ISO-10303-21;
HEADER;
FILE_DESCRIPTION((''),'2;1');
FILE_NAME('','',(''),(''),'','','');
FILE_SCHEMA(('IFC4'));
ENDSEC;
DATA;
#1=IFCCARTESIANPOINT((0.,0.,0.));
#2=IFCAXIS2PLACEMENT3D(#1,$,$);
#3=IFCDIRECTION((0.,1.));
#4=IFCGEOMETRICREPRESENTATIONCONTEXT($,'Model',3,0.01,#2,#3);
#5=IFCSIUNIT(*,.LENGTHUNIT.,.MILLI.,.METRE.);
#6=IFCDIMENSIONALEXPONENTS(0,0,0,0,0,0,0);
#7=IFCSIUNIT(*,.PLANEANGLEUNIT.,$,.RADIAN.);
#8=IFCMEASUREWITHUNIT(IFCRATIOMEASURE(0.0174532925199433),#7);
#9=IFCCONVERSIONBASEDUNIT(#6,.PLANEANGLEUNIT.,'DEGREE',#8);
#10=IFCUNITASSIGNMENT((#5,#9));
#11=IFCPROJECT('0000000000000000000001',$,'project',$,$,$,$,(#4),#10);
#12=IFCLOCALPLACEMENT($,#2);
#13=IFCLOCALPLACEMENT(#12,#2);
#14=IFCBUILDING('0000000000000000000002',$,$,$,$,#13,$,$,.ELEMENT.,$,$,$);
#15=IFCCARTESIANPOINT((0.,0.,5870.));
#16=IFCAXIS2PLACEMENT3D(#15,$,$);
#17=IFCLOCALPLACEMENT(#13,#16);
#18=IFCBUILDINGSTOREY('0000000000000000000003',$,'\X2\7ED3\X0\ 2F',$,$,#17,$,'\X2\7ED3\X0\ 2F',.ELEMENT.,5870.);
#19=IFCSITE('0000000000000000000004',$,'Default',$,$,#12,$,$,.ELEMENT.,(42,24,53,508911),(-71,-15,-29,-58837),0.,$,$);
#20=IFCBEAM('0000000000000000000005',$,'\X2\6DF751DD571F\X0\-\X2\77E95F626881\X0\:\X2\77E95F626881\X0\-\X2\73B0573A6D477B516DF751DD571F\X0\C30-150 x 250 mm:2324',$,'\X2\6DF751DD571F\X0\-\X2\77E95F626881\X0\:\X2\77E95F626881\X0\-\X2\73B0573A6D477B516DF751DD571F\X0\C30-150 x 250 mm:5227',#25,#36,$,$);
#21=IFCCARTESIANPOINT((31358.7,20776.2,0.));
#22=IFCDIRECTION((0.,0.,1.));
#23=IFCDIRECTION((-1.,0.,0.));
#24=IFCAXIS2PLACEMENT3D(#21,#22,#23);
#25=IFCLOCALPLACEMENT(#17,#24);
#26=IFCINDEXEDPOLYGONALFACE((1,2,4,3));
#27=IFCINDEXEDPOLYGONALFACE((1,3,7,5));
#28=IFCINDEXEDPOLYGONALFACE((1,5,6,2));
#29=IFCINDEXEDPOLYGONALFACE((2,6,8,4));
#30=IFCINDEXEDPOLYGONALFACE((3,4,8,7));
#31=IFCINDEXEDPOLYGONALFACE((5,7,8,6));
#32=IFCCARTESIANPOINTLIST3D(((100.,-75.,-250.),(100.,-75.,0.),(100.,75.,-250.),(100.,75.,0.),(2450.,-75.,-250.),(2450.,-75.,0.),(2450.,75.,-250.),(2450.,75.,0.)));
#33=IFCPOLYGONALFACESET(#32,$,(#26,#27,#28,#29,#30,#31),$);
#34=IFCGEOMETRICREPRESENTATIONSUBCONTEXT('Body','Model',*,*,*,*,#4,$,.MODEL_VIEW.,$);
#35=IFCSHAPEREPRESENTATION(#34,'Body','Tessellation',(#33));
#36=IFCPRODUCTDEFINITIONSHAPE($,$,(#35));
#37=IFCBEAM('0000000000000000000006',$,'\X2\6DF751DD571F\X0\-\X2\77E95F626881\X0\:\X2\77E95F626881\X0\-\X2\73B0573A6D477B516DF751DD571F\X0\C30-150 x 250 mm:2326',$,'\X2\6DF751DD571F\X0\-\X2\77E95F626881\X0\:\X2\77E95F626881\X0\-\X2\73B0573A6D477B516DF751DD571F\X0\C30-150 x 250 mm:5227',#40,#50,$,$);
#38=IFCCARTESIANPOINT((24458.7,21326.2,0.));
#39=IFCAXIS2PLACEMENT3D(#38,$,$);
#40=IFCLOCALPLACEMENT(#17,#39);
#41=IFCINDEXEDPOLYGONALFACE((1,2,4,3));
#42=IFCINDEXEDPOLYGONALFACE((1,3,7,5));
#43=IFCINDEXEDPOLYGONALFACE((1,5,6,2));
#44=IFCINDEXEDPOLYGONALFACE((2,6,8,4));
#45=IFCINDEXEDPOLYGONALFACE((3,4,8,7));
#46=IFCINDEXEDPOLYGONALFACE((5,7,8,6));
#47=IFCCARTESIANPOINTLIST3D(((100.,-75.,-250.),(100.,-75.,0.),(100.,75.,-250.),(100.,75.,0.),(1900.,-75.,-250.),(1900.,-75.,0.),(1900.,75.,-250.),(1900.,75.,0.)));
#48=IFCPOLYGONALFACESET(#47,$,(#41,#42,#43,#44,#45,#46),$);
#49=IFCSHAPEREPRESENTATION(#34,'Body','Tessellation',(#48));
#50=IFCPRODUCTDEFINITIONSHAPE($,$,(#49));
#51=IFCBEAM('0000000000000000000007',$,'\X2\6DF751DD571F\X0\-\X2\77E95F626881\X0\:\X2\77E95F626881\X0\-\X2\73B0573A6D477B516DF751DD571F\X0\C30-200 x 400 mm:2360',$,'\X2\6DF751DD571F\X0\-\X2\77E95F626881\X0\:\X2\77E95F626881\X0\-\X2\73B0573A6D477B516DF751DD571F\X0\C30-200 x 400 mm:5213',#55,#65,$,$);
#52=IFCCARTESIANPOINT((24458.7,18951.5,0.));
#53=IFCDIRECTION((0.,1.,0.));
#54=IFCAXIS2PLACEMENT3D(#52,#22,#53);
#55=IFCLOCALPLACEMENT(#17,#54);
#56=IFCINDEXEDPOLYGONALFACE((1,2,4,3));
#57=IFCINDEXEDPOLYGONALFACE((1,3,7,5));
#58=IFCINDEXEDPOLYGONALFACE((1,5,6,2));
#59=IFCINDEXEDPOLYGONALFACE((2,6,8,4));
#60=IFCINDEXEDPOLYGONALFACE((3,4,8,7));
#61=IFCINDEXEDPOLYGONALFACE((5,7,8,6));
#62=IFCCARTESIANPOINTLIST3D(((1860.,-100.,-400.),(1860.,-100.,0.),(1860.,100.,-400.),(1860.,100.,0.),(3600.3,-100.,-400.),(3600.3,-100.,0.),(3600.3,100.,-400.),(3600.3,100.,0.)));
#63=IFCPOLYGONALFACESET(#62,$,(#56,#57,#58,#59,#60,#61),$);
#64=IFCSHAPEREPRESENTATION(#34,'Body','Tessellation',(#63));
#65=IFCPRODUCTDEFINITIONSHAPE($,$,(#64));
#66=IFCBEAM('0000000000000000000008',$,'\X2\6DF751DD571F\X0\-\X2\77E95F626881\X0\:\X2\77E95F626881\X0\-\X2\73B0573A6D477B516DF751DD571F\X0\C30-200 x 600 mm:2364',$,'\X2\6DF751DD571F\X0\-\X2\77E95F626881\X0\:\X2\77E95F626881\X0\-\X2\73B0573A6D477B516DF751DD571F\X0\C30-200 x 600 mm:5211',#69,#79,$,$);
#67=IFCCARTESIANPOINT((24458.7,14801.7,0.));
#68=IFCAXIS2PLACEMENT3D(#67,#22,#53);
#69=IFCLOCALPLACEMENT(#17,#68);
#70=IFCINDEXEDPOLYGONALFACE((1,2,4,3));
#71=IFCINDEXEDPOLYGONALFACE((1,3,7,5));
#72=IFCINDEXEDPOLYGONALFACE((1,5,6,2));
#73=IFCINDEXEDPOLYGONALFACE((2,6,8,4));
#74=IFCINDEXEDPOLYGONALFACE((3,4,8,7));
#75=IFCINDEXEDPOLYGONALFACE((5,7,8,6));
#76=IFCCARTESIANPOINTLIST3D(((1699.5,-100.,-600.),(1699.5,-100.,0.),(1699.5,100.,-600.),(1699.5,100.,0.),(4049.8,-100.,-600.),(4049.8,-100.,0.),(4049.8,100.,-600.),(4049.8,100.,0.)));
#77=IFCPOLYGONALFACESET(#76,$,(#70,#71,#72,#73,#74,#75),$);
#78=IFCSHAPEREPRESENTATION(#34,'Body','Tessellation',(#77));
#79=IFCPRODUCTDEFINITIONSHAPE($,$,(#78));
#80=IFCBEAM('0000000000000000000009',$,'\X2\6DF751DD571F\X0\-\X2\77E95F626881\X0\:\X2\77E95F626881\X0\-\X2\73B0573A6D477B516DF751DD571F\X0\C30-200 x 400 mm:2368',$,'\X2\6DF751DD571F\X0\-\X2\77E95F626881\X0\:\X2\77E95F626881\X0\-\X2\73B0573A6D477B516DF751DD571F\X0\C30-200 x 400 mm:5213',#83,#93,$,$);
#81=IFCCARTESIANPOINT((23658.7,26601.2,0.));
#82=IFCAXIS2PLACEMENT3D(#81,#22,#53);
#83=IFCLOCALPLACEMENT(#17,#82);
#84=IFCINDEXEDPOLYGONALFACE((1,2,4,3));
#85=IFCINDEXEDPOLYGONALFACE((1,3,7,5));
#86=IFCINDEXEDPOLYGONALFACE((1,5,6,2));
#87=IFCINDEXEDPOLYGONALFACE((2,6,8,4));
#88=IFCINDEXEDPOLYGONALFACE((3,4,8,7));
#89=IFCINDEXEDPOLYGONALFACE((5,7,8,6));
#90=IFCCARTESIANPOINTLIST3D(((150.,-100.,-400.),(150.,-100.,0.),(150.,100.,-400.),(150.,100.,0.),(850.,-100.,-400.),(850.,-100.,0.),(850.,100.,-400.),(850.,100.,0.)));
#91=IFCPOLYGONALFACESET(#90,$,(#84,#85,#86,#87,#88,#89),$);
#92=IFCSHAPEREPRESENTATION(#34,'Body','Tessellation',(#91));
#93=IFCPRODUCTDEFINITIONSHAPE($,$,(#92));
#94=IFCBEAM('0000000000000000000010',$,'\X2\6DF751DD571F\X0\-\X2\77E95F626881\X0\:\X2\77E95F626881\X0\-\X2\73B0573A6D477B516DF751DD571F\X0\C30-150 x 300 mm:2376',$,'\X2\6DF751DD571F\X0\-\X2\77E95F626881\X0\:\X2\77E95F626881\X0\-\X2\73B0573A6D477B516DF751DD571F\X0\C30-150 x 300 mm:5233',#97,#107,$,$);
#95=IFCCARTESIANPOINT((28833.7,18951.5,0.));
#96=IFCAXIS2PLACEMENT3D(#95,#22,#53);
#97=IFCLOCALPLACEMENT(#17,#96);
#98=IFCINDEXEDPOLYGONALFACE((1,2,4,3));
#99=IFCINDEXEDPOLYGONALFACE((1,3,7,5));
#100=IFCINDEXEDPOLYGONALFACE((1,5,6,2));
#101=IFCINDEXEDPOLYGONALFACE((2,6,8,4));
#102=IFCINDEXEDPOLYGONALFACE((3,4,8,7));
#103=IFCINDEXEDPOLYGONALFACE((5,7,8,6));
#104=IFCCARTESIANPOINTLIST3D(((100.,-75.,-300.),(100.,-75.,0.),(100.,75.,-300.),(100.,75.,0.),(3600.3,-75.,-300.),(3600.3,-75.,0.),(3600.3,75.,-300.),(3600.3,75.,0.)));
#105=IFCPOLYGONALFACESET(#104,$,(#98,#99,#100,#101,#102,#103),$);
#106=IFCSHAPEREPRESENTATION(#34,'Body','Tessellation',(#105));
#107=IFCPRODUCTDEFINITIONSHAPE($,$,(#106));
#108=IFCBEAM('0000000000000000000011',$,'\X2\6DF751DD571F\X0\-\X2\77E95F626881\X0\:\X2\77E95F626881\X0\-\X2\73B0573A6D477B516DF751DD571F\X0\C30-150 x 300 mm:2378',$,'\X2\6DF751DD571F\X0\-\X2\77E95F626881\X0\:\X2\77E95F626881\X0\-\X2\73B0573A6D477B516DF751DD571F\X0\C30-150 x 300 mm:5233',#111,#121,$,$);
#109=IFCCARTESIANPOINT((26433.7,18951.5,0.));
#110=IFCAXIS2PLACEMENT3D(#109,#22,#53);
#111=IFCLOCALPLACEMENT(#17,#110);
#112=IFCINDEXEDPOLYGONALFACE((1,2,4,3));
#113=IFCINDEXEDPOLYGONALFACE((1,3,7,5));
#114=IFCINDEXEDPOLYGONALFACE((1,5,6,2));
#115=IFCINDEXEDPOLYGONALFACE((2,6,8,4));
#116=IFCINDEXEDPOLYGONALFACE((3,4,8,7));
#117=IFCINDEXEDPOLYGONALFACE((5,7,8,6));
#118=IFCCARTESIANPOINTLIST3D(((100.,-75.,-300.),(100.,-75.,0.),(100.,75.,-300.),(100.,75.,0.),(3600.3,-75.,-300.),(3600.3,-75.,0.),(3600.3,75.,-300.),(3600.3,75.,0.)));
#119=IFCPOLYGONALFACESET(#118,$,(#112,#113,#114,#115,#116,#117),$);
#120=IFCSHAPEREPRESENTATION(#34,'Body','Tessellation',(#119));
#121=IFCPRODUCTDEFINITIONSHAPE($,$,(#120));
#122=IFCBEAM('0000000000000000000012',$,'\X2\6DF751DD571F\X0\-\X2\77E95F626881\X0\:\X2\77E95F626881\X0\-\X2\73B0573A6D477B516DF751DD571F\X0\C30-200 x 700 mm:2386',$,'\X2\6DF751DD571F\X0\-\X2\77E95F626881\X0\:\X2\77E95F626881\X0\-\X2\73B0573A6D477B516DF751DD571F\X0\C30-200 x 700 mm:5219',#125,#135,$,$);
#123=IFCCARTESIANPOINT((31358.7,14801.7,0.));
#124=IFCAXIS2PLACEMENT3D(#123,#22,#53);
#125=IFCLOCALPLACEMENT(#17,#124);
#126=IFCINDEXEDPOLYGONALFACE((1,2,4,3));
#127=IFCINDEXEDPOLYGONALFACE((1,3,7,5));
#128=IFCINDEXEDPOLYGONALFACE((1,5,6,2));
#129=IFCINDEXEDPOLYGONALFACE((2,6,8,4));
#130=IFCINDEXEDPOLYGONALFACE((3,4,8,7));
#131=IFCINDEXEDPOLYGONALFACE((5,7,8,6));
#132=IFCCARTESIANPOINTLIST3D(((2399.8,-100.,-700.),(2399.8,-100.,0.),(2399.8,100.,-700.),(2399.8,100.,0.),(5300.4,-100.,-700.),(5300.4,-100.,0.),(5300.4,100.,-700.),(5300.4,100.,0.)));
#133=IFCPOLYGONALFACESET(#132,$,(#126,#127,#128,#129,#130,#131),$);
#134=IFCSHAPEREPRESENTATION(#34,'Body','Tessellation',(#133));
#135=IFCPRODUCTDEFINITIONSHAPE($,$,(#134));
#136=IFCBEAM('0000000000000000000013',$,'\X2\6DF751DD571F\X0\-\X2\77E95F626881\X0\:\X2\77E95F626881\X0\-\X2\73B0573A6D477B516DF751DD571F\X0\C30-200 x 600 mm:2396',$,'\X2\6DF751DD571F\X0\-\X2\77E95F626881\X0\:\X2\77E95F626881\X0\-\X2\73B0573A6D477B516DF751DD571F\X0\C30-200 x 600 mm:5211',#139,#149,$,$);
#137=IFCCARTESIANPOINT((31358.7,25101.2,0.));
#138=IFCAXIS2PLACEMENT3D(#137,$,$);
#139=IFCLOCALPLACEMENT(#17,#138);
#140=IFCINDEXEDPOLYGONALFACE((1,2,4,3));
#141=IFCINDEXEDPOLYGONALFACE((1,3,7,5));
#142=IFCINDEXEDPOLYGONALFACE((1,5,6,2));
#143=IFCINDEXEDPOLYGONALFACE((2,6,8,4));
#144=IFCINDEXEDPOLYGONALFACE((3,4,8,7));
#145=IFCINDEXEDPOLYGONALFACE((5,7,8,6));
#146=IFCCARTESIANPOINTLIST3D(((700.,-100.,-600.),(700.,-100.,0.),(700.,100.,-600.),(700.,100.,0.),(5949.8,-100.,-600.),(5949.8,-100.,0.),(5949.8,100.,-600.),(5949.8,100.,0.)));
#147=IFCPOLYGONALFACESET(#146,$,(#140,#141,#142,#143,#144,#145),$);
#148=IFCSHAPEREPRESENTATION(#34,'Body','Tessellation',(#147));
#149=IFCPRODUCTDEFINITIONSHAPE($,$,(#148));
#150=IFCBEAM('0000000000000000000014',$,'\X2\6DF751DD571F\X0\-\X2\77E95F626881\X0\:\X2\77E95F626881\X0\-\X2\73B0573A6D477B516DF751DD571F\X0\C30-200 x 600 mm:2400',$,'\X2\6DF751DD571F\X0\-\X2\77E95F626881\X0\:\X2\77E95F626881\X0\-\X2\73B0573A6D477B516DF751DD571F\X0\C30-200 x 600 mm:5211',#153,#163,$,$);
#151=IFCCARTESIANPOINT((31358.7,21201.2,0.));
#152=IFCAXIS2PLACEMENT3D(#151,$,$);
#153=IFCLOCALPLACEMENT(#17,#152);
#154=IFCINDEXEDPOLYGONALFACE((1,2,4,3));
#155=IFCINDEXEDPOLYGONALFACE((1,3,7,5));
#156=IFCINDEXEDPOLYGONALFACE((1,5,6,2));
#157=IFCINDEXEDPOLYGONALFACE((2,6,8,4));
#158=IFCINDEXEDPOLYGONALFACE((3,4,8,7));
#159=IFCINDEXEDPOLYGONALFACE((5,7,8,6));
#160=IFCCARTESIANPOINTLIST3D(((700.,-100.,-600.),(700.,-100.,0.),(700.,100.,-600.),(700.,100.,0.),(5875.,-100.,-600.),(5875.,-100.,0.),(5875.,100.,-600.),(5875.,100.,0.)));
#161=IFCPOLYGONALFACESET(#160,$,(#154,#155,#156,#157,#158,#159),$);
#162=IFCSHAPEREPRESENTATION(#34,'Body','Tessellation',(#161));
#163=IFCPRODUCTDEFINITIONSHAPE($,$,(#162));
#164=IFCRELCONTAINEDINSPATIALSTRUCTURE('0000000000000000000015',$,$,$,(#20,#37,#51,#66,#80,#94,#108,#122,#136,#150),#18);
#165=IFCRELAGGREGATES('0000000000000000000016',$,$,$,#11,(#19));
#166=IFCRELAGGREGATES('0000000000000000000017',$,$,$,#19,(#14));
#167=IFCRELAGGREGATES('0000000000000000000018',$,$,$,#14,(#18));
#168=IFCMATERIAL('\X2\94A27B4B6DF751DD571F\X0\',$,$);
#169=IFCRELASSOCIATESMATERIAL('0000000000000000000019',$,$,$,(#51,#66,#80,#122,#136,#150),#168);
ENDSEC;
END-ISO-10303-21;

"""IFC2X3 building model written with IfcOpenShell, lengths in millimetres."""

from ifc_helpers import new_model, entity, si_unit, converted_unit, direction, frame, frame_2d, origin, place, context, subcontext, project, spatial, rectangle, extrude, material, element, save


model = new_model("IFC2X3")

# Units and contexts
model_context = context("Model", 3, precision=0.01, world=origin(), true_north=direction((0.0, 1.0)))
body_context = subcontext(model_context, "Body", "Model", "MODEL_VIEW")
ifc_project = project(units=[si_unit("LENGTHUNIT", "METRE", prefix="MILLI"), converted_unit("PLANEANGLEUNIT", "DEGREE", entity("IfcRatioMeasure", 0.0174532925199433), si_unit("PLANEANGLEUNIT", "RADIAN"), dimensions=[0, 0, 0, 0, 0, 0, 0])], contexts=[model_context])

# Site, building, storey
site_placement = place(None, origin())
site = spatial("IfcSite", under=ifc_project, at=site_placement, Name="Default", CompositionType="ELEMENT", RefLatitude=(42, 24, 53, 508911), RefLongitude=(-71, -15, -29, -58837), RefElevation=0.0)
building_placement = place(site_placement, origin())
building = spatial("IfcBuilding", under=site, at=building_placement, CompositionType="ELEMENT")
storey_placement = place(building_placement, frame((0.0, 0.0, 5870.0)))
storey = spatial("IfcBuildingStorey", under=building, at=storey_placement, Name="结 2F", LongName="结 2F", CompositionType="ELEMENT", Elevation=5870.0)

# Beams
beam_1_placement = place(storey_placement, frame((31358.7, 20776.2, 0.0), z_axis=(0.0, 0.0, 1.0), x_axis=(-1.0, 0.0, 0.0)))
element("IfcBeam", 1, at=beam_1_placement, inside=storey, Name="混凝土-矩形梁:矩形梁-现场浇筑混凝土C30-150 x 250 mm:2324", ObjectType="混凝土-矩形梁:矩形梁-现场浇筑混凝土C30-150 x 250 mm:5227", context=body_context, shape_type="SweptSolid", body=[
    extrude(rectangle(XDim=250.0, YDim=150.0, at=frame_2d((0.0, 0.0), x_axis=(1.0, 0.0))), frame((100.0, 0.0, -125.0), z_axis=(1.0, 0.0, 0.0), x_axis=(0.0, 0.0, -1.0)), (0.0, 0.0, 1.0), 2350.0),
])
beam_2_placement = place(storey_placement, frame((24458.7, 21326.2, 0.0)))
element("IfcBeam", 2, at=beam_2_placement, inside=storey, Name="混凝土-矩形梁:矩形梁-现场浇筑混凝土C30-150 x 250 mm:2326", ObjectType="混凝土-矩形梁:矩形梁-现场浇筑混凝土C30-150 x 250 mm:5227", context=body_context, shape_type="SweptSolid", body=[
    extrude(rectangle(XDim=250.0, YDim=150.0, at=frame_2d((0.0, 0.0), x_axis=(1.0, 0.0))), frame((100.0, 0.0, -125.0), z_axis=(1.0, 0.0, 0.0), x_axis=(0.0, 0.0, -1.0)), (0.0, 0.0, 1.0), 1800.0),
])
ifc_material = material(Name="钢筋混凝土")
beam_3_placement = place(storey_placement, frame((24458.7, 18951.5, 0.0), z_axis=(0.0, 0.0, 1.0), x_axis=(0.0, 1.0, 0.0)))
element("IfcBeam", 3, at=beam_3_placement, inside=storey, material=ifc_material, Name="混凝土-矩形梁:矩形梁-现场浇筑混凝土C30-200 x 400 mm:2360", ObjectType="混凝土-矩形梁:矩形梁-现场浇筑混凝土C30-200 x 400 mm:5213", context=body_context, shape_type="SweptSolid", body=[
    extrude(rectangle(XDim=400.0, YDim=200.0, at=frame_2d((0.0, 0.0), x_axis=(1.0, 0.0))), frame((1860.0, 0.0, -200.0), z_axis=(1.0, 0.0, 0.0), x_axis=(0.0, 0.0, -1.0)), (0.0, 0.0, 1.0), 1740.3),
])
beam_4_placement = place(storey_placement, frame((24458.7, 14801.7, 0.0), z_axis=(0.0, 0.0, 1.0), x_axis=(0.0, 1.0, 0.0)))
element("IfcBeam", 4, at=beam_4_placement, inside=storey, material=ifc_material, Name="混凝土-矩形梁:矩形梁-现场浇筑混凝土C30-200 x 600 mm:2364", ObjectType="混凝土-矩形梁:矩形梁-现场浇筑混凝土C30-200 x 600 mm:5211", context=body_context, shape_type="SweptSolid", body=[
    extrude(rectangle(XDim=600.0, YDim=200.0, at=frame_2d((0.0, 0.0), x_axis=(1.0, 0.0))), frame((1699.5, 0.0, -300.0), z_axis=(1.0, 0.0, 0.0), x_axis=(0.0, 0.0, -1.0)), (0.0, 0.0, 1.0), 2350.2),
])
beam_5_placement = place(storey_placement, frame((23658.7, 26601.2, 0.0), z_axis=(0.0, 0.0, 1.0), x_axis=(0.0, 1.0, 0.0)))
element("IfcBeam", 5, at=beam_5_placement, inside=storey, material=ifc_material, Name="混凝土-矩形梁:矩形梁-现场浇筑混凝土C30-200 x 400 mm:2368", ObjectType="混凝土-矩形梁:矩形梁-现场浇筑混凝土C30-200 x 400 mm:5213", context=body_context, shape_type="SweptSolid", body=[
    extrude(rectangle(XDim=400.0, YDim=200.0, at=frame_2d((0.0, 0.0), x_axis=(1.0, 0.0))), frame((150.0, 0.0, -200.0), z_axis=(1.0, 0.0, 0.0), x_axis=(0.0, 0.0, -1.0)), (0.0, 0.0, 1.0), 700.0),
])
beam_6_placement = place(storey_placement, frame((28833.7, 18951.5, 0.0), z_axis=(0.0, 0.0, 1.0), x_axis=(0.0, 1.0, 0.0)))
element("IfcBeam", 6, at=beam_6_placement, inside=storey, Name="混凝土-矩形梁:矩形梁-现场浇筑混凝土C30-150 x 300 mm:2376", ObjectType="混凝土-矩形梁:矩形梁-现场浇筑混凝土C30-150 x 300 mm:5233", context=body_context, shape_type="SweptSolid", body=[
    extrude(rectangle(XDim=300.0, YDim=150.0, at=frame_2d((0.0, 0.0), x_axis=(1.0, 0.0))), frame((100.0, 0.0, -150.0), z_axis=(1.0, 0.0, 0.0), x_axis=(0.0, 0.0, -1.0)), (0.0, 0.0, 1.0), 3500.3),
])
beam_7_placement = place(storey_placement, frame((26433.7, 18951.5, 0.0), z_axis=(0.0, 0.0, 1.0), x_axis=(0.0, 1.0, 0.0)))
element("IfcBeam", 7, at=beam_7_placement, inside=storey, Name="混凝土-矩形梁:矩形梁-现场浇筑混凝土C30-150 x 300 mm:2378", ObjectType="混凝土-矩形梁:矩形梁-现场浇筑混凝土C30-150 x 300 mm:5233", context=body_context, shape_type="SweptSolid", body=[
    extrude(rectangle(XDim=300.0, YDim=150.0, at=frame_2d((0.0, 0.0), x_axis=(1.0, 0.0))), frame((100.0, 0.0, -150.0), z_axis=(1.0, 0.0, 0.0), x_axis=(0.0, 0.0, -1.0)), (0.0, 0.0, 1.0), 3500.3),
])
beam_8_placement = place(storey_placement, frame((31358.7, 14801.7, 0.0), z_axis=(0.0, 0.0, 1.0), x_axis=(0.0, 1.0, 0.0)))
element("IfcBeam", 8, at=beam_8_placement, inside=storey, material=ifc_material, Name="混凝土-矩形梁:矩形梁-现场浇筑混凝土C30-200 x 700 mm:2386", ObjectType="混凝土-矩形梁:矩形梁-现场浇筑混凝土C30-200 x 700 mm:5219", context=body_context, shape_type="SweptSolid", body=[
    extrude(rectangle(XDim=700.0, YDim=200.0, at=frame_2d((0.0, 0.0), x_axis=(1.0, 0.0))), frame((2399.8, 0.0, -350.0), z_axis=(1.0, 0.0, 0.0), x_axis=(0.0, 0.0, -1.0)), (0.0, 0.0, 1.0), 2900.6),
])
beam_9_placement = place(storey_placement, frame((31358.7, 25101.2, 0.0)))
element("IfcBeam", 9, at=beam_9_placement, inside=storey, material=ifc_material, Name="混凝土-矩形梁:矩形梁-现场浇筑混凝土C30-200 x 600 mm:2396", ObjectType="混凝土-矩形梁:矩形梁-现场浇筑混凝土C30-200 x 600 mm:5211", context=body_context, shape_type="SweptSolid", body=[
    extrude(rectangle(XDim=600.0, YDim=200.0, at=frame_2d((0.0, 0.0), x_axis=(1.0, 0.0))), frame((700.0, 0.0, -300.0), z_axis=(1.0, 0.0, 0.0), x_axis=(0.0, 0.0, -1.0)), (0.0, 0.0, 1.0), 5249.8),
])
beam_10_placement = place(storey_placement, frame((31358.7, 21201.2, 0.0)))
element("IfcBeam", 10, at=beam_10_placement, inside=storey, material=ifc_material, Name="混凝土-矩形梁:矩形梁-现场浇筑混凝土C30-200 x 600 mm:2400", ObjectType="混凝土-矩形梁:矩形梁-现场浇筑混凝土C30-200 x 600 mm:5211", context=body_context, shape_type="SweptSolid", body=[
    extrude(rectangle(XDim=600.0, YDim=200.0, at=frame_2d((0.0, 0.0), x_axis=(1.0, 0.0))), frame((700.0, 0.0, -300.0), z_axis=(1.0, 0.0, 0.0), x_axis=(0.0, 0.0, -1.0)), (0.0, 0.0, 1.0), 5175.0),
])

save(model, "model.ifc")
